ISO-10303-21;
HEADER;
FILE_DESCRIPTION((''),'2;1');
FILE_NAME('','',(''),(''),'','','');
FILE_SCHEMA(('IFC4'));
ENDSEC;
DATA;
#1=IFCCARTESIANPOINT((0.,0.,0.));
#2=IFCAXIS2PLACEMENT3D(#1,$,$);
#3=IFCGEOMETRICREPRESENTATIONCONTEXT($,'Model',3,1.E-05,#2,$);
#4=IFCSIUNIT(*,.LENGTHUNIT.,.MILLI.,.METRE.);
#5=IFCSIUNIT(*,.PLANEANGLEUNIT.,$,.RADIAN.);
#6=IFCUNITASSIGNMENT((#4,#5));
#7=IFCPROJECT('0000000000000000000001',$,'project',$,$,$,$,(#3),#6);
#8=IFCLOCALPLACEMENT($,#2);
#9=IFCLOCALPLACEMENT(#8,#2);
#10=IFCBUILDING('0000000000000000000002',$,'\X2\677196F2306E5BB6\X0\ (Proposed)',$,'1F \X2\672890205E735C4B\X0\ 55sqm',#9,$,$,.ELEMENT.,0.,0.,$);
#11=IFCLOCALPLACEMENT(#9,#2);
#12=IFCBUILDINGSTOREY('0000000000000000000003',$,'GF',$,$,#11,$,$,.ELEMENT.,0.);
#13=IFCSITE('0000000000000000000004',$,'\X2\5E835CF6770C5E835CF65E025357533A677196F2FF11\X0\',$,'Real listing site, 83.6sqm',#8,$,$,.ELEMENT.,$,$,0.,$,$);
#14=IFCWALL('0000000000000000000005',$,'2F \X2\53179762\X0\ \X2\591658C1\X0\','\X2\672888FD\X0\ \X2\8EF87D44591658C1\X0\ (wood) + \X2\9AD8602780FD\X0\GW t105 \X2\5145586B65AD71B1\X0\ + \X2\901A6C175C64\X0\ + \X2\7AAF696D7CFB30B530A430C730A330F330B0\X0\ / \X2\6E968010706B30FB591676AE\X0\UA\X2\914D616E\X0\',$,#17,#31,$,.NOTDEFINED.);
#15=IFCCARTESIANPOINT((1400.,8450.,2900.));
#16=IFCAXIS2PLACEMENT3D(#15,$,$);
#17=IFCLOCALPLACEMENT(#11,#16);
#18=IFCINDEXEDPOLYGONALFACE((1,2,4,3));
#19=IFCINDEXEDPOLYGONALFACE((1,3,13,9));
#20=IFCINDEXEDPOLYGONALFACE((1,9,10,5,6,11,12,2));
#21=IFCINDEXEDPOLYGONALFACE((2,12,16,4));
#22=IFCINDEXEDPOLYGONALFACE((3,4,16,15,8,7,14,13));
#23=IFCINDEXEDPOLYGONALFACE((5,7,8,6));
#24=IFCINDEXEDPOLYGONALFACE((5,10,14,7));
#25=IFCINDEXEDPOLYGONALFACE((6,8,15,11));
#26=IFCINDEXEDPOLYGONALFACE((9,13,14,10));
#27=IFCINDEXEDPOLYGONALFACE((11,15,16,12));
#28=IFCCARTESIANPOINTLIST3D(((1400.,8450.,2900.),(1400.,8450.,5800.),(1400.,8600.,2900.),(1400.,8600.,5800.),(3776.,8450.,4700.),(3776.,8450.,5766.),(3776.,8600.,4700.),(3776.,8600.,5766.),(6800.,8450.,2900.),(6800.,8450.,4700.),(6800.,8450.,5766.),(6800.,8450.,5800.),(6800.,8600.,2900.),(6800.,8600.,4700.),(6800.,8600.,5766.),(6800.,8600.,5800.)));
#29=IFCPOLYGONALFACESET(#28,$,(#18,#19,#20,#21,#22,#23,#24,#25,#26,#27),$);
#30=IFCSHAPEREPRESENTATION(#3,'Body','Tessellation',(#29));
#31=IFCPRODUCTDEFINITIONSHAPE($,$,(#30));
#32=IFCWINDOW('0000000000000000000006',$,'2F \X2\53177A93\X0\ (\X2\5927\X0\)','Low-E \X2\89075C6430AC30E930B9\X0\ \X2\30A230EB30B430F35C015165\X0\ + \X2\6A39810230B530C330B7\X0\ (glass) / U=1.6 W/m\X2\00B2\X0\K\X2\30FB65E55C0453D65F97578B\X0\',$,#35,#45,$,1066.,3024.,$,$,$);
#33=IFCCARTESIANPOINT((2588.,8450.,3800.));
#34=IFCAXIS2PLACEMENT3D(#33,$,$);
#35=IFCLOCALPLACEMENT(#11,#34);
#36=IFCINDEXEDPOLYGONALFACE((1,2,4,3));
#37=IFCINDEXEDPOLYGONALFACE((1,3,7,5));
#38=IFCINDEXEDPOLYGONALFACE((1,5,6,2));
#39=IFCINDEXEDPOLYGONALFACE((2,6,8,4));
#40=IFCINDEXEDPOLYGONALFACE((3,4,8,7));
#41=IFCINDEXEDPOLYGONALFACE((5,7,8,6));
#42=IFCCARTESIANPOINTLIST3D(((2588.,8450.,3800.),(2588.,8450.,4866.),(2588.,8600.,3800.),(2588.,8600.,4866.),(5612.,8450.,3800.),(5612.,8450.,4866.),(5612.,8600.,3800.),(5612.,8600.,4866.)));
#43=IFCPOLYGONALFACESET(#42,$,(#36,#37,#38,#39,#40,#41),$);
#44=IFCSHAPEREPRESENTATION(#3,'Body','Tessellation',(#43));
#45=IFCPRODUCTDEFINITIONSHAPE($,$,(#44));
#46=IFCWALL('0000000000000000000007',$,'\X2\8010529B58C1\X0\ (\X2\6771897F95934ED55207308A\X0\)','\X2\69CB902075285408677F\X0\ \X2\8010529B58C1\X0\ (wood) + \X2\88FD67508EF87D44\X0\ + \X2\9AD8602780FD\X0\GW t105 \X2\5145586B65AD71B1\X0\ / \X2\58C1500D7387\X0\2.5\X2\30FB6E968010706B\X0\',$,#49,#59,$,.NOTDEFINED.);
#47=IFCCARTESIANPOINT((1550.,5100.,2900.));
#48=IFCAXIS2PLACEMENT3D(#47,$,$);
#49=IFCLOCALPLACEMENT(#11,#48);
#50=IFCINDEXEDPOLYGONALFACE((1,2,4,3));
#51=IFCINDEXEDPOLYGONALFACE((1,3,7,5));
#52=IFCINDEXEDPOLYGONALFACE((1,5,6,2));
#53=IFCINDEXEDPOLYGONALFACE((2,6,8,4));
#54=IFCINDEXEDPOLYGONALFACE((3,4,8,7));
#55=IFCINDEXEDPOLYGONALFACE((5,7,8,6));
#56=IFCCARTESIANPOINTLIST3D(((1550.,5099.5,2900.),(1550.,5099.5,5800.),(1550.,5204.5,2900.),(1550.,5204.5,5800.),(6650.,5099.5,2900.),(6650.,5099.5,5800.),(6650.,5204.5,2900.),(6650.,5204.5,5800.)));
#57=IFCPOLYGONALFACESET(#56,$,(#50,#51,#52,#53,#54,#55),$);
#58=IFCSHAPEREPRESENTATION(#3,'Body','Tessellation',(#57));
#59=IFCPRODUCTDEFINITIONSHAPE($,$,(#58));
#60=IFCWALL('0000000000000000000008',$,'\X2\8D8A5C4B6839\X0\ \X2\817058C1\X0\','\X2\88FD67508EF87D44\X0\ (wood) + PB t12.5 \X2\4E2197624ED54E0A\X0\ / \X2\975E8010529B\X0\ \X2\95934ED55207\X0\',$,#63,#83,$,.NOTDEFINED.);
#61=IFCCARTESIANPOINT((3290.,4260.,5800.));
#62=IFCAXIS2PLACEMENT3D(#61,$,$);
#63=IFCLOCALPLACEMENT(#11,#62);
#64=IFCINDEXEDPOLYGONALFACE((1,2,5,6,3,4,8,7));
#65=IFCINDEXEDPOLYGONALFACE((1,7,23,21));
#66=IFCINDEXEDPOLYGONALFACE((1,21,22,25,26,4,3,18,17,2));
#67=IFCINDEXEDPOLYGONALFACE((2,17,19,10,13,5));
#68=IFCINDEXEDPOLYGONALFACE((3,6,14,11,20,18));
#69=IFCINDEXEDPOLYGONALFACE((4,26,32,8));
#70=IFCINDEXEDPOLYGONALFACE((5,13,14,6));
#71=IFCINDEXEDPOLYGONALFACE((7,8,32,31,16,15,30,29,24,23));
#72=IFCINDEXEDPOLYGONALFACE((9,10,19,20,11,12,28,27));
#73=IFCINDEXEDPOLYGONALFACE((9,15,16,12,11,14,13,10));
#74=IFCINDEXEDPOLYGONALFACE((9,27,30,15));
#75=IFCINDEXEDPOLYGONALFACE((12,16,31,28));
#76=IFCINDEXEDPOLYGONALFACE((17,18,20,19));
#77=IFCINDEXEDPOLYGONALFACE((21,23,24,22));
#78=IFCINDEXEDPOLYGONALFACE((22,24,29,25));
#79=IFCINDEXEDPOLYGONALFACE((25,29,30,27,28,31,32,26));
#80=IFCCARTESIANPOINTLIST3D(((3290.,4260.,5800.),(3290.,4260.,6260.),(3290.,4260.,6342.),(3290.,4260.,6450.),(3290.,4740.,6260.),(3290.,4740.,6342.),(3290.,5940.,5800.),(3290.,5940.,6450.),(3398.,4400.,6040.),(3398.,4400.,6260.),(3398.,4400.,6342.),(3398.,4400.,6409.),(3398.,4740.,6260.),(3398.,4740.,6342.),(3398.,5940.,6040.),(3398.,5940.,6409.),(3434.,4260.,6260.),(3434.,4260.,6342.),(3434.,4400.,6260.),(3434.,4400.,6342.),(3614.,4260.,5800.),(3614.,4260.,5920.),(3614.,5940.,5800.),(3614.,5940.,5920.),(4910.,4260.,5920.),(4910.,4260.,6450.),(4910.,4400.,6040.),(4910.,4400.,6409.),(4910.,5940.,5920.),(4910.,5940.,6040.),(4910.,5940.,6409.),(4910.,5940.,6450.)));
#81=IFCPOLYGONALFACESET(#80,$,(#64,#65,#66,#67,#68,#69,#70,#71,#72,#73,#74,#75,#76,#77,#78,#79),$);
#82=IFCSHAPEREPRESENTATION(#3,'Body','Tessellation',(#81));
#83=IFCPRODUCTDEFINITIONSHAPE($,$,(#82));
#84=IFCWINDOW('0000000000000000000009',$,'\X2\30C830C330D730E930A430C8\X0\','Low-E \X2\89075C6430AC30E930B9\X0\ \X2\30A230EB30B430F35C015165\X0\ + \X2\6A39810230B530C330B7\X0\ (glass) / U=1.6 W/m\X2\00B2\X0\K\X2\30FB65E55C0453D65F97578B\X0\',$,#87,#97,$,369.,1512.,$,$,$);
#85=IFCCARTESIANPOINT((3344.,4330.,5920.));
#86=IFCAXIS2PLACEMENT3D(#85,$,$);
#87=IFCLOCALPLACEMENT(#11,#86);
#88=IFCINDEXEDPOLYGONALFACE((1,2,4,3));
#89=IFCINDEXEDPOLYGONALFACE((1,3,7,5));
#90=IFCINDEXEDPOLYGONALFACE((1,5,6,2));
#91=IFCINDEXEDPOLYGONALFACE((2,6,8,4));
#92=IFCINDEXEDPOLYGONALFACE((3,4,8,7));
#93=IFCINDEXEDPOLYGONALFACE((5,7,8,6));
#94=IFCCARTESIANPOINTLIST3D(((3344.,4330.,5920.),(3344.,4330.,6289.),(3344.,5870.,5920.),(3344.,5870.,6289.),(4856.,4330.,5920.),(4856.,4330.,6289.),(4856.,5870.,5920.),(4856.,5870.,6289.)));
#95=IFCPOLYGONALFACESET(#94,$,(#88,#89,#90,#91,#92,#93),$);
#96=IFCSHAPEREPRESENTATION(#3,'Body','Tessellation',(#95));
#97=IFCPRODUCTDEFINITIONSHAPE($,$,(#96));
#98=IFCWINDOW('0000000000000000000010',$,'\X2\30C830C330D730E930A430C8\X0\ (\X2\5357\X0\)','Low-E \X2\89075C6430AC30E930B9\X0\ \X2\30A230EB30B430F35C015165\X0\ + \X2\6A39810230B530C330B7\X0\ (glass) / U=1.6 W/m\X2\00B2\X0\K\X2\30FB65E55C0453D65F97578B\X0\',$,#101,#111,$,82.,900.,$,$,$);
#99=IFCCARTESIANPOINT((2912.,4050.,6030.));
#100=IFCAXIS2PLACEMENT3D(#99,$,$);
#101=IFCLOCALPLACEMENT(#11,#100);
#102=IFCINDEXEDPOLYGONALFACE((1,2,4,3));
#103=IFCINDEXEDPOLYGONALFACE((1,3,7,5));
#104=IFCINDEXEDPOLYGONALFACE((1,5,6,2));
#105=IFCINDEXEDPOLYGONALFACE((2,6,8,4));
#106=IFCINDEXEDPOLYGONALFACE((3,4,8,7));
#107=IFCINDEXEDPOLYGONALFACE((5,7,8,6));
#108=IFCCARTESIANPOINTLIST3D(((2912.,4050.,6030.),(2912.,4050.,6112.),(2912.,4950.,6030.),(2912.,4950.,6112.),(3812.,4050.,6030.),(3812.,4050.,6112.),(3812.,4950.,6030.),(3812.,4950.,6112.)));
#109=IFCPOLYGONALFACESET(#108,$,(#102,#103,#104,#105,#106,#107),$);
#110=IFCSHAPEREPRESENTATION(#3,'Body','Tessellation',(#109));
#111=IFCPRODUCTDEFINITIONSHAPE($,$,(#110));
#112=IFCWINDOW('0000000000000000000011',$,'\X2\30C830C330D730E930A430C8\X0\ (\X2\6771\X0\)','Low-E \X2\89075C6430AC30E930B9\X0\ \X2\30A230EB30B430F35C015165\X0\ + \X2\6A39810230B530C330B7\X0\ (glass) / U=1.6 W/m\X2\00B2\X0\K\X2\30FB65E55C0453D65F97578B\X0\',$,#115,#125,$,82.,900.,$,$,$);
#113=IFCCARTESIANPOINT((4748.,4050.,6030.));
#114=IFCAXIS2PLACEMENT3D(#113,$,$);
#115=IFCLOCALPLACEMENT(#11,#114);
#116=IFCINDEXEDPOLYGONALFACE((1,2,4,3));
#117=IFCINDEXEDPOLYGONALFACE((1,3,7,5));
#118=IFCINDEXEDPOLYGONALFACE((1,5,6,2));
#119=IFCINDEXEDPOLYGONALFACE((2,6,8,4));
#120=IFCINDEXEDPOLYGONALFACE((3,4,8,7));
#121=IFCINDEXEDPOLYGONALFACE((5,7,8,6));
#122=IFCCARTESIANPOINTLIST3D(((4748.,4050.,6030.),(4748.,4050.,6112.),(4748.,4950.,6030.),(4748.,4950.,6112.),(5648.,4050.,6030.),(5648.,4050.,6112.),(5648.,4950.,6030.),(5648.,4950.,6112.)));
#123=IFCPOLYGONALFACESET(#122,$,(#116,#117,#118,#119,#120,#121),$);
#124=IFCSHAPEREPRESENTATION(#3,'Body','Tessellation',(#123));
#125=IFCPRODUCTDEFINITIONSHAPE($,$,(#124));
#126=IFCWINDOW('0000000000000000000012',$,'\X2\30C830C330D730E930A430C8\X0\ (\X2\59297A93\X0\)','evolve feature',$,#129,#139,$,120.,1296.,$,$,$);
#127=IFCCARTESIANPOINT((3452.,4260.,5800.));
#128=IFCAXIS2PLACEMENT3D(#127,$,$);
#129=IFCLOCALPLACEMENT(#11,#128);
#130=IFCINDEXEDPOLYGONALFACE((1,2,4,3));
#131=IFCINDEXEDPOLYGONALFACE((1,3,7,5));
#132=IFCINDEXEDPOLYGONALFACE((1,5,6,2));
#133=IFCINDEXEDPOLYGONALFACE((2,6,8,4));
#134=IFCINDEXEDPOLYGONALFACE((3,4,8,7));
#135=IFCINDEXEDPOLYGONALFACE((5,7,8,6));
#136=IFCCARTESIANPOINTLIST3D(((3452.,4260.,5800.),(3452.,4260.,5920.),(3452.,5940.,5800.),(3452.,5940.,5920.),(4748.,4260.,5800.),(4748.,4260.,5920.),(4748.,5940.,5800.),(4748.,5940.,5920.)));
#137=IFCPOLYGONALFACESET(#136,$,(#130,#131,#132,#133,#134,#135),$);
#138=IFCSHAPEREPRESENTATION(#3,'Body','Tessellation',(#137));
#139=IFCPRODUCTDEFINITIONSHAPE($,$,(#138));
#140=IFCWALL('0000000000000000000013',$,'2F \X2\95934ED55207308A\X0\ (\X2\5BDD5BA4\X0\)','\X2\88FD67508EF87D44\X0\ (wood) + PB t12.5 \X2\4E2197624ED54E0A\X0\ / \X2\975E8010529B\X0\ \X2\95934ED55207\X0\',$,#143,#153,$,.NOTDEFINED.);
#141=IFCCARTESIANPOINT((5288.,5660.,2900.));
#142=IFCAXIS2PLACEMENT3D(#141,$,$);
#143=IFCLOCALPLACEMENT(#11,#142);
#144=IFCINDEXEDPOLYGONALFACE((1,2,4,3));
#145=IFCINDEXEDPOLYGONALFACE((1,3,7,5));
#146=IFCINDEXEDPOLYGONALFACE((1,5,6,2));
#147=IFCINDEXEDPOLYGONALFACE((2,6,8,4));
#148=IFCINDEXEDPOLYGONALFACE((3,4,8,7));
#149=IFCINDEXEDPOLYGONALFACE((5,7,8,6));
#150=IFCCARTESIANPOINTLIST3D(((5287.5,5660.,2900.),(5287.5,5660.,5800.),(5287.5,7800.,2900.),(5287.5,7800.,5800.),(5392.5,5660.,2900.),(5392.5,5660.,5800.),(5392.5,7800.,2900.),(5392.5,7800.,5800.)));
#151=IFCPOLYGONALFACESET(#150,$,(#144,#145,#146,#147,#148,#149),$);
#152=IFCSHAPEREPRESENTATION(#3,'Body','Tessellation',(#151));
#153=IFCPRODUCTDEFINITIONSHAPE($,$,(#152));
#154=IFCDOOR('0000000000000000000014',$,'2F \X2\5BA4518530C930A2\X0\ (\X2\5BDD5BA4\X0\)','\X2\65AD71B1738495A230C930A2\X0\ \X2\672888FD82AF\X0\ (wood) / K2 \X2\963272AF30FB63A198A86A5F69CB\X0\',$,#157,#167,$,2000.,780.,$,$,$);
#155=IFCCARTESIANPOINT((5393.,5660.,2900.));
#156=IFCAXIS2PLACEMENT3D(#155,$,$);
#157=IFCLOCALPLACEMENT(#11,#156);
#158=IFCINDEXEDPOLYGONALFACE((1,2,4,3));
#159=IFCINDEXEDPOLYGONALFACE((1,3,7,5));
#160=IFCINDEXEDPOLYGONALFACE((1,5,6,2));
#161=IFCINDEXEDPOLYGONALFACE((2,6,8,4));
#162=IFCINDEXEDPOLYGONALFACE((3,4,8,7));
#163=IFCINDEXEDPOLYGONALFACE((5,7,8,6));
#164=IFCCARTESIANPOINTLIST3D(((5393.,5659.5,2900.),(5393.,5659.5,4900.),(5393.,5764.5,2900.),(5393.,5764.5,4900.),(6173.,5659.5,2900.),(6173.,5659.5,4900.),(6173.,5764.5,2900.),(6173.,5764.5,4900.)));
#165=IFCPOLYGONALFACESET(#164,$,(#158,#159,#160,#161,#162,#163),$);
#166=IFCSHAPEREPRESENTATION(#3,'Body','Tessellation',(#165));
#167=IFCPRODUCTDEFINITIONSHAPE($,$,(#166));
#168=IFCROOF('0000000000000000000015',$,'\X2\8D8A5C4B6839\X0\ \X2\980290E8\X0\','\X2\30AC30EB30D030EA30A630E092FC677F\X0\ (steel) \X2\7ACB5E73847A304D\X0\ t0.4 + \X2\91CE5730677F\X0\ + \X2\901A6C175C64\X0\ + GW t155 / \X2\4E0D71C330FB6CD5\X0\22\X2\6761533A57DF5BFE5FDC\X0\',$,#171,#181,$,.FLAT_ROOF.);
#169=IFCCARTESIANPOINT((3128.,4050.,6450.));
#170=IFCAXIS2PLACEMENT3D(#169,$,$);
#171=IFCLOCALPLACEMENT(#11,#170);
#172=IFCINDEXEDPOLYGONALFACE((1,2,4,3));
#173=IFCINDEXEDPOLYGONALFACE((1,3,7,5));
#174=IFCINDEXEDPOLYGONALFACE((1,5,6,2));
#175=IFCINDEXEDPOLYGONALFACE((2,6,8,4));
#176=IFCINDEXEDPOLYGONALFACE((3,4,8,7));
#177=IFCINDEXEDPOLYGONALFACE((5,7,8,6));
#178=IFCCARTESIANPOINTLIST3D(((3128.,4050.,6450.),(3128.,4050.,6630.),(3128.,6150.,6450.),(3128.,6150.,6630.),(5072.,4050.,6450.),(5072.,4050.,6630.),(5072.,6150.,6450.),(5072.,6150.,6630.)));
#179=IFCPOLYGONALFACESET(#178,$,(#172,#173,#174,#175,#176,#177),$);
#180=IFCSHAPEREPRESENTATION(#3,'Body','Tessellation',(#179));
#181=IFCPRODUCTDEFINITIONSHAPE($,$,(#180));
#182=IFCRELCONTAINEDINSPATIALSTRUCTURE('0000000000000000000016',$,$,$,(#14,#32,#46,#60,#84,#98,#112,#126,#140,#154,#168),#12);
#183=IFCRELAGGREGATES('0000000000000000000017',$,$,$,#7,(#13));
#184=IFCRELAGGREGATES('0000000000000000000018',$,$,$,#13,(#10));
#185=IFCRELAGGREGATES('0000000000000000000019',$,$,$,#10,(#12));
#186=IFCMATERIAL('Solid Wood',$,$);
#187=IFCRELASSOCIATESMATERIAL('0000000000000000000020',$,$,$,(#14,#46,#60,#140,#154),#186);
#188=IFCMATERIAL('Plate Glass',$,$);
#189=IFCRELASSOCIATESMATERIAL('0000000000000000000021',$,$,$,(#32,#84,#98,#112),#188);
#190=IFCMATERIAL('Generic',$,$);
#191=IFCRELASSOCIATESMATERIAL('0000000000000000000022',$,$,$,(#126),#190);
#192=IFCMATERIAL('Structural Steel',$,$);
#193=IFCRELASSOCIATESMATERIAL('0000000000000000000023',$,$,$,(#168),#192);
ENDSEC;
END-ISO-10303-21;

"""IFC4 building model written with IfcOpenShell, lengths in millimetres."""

from ifc_helpers import new_model, si_unit, frame, frame_2d, origin, place, context, project, spatial, rectangle, extrude, material, element, fill, save


model = new_model("IFC4")

# Units and contexts
model_context = context("Model", 3, precision=1e-05, world=origin())
ifc_project = project(units=[si_unit("LENGTHUNIT", "METRE", prefix="MILLI"), si_unit("PLANEANGLEUNIT", "RADIAN")], contexts=[model_context])

# Site, building, storey
site_placement = place(None, origin())
site = spatial("IfcSite", under=ifc_project, at=site_placement, Name="広島県広島市南区東雲１", ObjectType="Real listing site, 83.6sqm", CompositionType="ELEMENT", RefElevation=0.0)
building_placement = place(site_placement, origin())
building = spatial("IfcBuilding", under=site, at=building_placement, Name="東雲の家 (Proposed)", ObjectType="1F 木造平屋 55sqm", CompositionType="ELEMENT", ElevationOfRefHeight=0.0, ElevationOfTerrain=0.0)
storey_placement = place(building_placement, origin())
storey = spatial("IfcBuildingStorey", under=building, at=storey_placement, Name="GF", CompositionType="ELEMENT", Elevation=0.0)

# Wall, opening, window
ifc_material_1 = material(Name="Solid Wood")
wall_1_placement = place(storey_placement, frame((1400.0, 8450.0, 2900.0)))
wall_1 = element("IfcWall", 1, at=wall_1_placement, inside=storey, material=ifc_material_1, Name="2F 北面 外壁", Description="木製 軸組外壁 (wood) + 高性能GW t105 充填断熱 + 通気層 + 窯業系サイディング / 準耐火・外皮UA配慮", PredefinedType="NOTDEFINED", context=model_context, shape_type="SweptSolid", body=[
    extrude(rectangle(XDim=5400.0, YDim=150.0, at=frame_2d((2700.0, 75.0))), frame((1400.0, 8450.0, 2900.0)), (0.0, 0.0, 1.0), 2900.0),
])
opening_1_placement = place(storey_placement, frame((2588.0, 8450.0, 3800.0)))
opening_1 = element("IfcOpeningElement", 2, at=opening_1_placement, cuts=wall_1, PredefinedType="NOTDEFINED", context=model_context, shape_type="SweptSolid", body=[
    extrude(rectangle(XDim=3024.0, YDim=150.0, at=frame_2d((1512.0, 75.0))), frame((2588.0, 8450.0, 3800.0)), (0.0, 0.0, 1.0), 1066.0),
])
ifc_material_2 = material(Name="Plate Glass")
window_1_placement = place(storey_placement, frame((2588.0, 8450.0, 3800.0)))
window_1 = element("IfcWindow", 3, at=window_1_placement, inside=storey, material=ifc_material_2, Name="2F 北窓 (大)", Description="Low-E 複層ガラス アルゴン封入 + 樹脂サッシ (glass) / U=1.6 W/m²K・日射取得型", OverallHeight=1066.0, OverallWidth=3024.0, context=model_context, shape_type="SweptSolid", body=[
    extrude(rectangle(XDim=3024.0, YDim=150.0, at=frame_2d((1512.0, 75.0))), frame((2588.0, 8450.0, 3800.0)), (0.0, 0.0, 1.0), 1066.0),
])
fill(opening_1, window_1)

# Wall
wall_2_placement = place(storey_placement, frame((1550.0, 5100.0, 2900.0)))
element("IfcWall", 4, at=wall_2_placement, inside=storey, material=ifc_material_1, Name="耐力壁 (東西間仕切り)", Description="構造用合板 耐力壁 (wood) + 製材軸組 + 高性能GW t105 充填断熱 / 壁倍率2.5・準耐火", PredefinedType="NOTDEFINED", context=model_context, shape_type="SweptSolid", body=[
    extrude(rectangle(XDim=5100.0, YDim=105.0, at=frame_2d((2550.0, 52.0))), frame((1550.0, 5100.0, 2900.0)), (0.0, 0.0, 1.0), 2900.0),
])

# Wall, openings, windows
wall_3_placement = place(storey_placement, frame((3290.0, 4260.0, 5800.0)))
wall_3 = element("IfcWall", 5, at=wall_3_placement, inside=storey, material=ifc_material_1, Name="越屋根 腰壁", Description="製材軸組 (wood) + PB t12.5 両面仕上 / 非耐力 間仕切", PredefinedType="NOTDEFINED", context=model_context, shape_type="SweptSolid", body=[
    extrude(rectangle(XDim=1620.0, YDim=1680.0, at=frame_2d((810.0, 840.0))), frame((3290.0, 4260.0, 5800.0)), (0.0, 0.0, 1.0), 650.0),
])
opening_2_placement = place(storey_placement, frame((3344.0, 4330.0, 5920.0)))
opening_2 = element("IfcOpeningElement", 6, at=opening_2_placement, cuts=wall_3, PredefinedType="NOTDEFINED", context=model_context, shape_type="SweptSolid", body=[
    extrude(rectangle(XDim=1512.0, YDim=1540.0, at=frame_2d((756.0, 770.0))), frame((3344.0, 4330.0, 5920.0)), (0.0, 0.0, 1.0), 369.0),
])
opening_3_placement = place(storey_placement, frame((2912.0, 4050.0, 6030.0)))
opening_3 = element("IfcOpeningElement", 7, at=opening_3_placement, cuts=wall_3, PredefinedType="NOTDEFINED", context=model_context, shape_type="SweptSolid", body=[
    extrude(rectangle(XDim=900.0, YDim=900.0, at=frame_2d((450.0, 450.0))), frame((2912.0, 4050.0, 6030.0)), (0.0, 0.0, 1.0), 82.0),
])
opening_4_placement = place(storey_placement, frame((4748.0, 4050.0, 6030.0)))
opening_4 = element("IfcOpeningElement", 8, at=opening_4_placement, cuts=wall_3, PredefinedType="NOTDEFINED", context=model_context, shape_type="SweptSolid", body=[
    extrude(rectangle(XDim=900.0, YDim=900.0, at=frame_2d((450.0, 450.0))), frame((4748.0, 4050.0, 6030.0)), (0.0, 0.0, 1.0), 82.0),
])
opening_5_placement = place(storey_placement, frame((3452.0, 4260.0, 5800.0)))
opening_5 = element("IfcOpeningElement", 9, at=opening_5_placement, cuts=wall_3, PredefinedType="NOTDEFINED", context=model_context, shape_type="SweptSolid", body=[
    extrude(rectangle(XDim=1296.0, YDim=1680.0, at=frame_2d((648.0, 840.0))), frame((3452.0, 4260.0, 5800.0)), (0.0, 0.0, 1.0), 120.0),
])
window_2_placement = place(storey_placement, frame((3344.0, 4330.0, 5920.0)))
window_2 = element("IfcWindow", 10, at=window_2_placement, inside=storey, material=ifc_material_2, Name="トップライト", Description="Low-E 複層ガラス アルゴン封入 + 樹脂サッシ (glass) / U=1.6 W/m²K・日射取得型", OverallHeight=369.0, OverallWidth=1512.0, context=model_context, shape_type="SweptSolid", body=[
    extrude(rectangle(XDim=1512.0, YDim=1540.0, at=frame_2d((756.0, 770.0))), frame((3344.0, 4330.0, 5920.0)), (0.0, 0.0, 1.0), 369.0),
])
fill(opening_2, window_2)
window_3_placement = place(storey_placement, frame((2912.0, 4050.0, 6030.0)))
window_3 = element("IfcWindow", 11, at=window_3_placement, inside=storey, material=ifc_material_2, Name="トップライト (南)", Description="Low-E 複層ガラス アルゴン封入 + 樹脂サッシ (glass) / U=1.6 W/m²K・日射取得型", OverallHeight=82.0, OverallWidth=900.0, context=model_context, shape_type="SweptSolid", body=[
    extrude(rectangle(XDim=900.0, YDim=900.0, at=frame_2d((450.0, 450.0))), frame((2912.0, 4050.0, 6030.0)), (0.0, 0.0, 1.0), 82.0),
])
fill(opening_3, window_3)
window_4_placement = place(storey_placement, frame((4748.0, 4050.0, 6030.0)))
window_4 = element("IfcWindow", 12, at=window_4_placement, inside=storey, material=ifc_material_2, Name="トップライト (東)", Description="Low-E 複層ガラス アルゴン封入 + 樹脂サッシ (glass) / U=1.6 W/m²K・日射取得型", OverallHeight=82.0, OverallWidth=900.0, context=model_context, shape_type="SweptSolid", body=[
    extrude(rectangle(XDim=900.0, YDim=900.0, at=frame_2d((450.0, 450.0))), frame((4748.0, 4050.0, 6030.0)), (0.0, 0.0, 1.0), 82.0),
])
fill(opening_4, window_4)
ifc_material_3 = material(Name="Generic")
window_5_placement = place(storey_placement, frame((3452.0, 4260.0, 5800.0)))
window_5 = element("IfcWindow", 13, at=window_5_placement, inside=storey, material=ifc_material_3, Name="トップライト (天窓)", Description="evolve feature", OverallHeight=120.0, OverallWidth=1296.0, context=model_context, shape_type="SweptSolid", body=[
    extrude(rectangle(XDim=1296.0, YDim=1680.0, at=frame_2d((648.0, 840.0))), frame((3452.0, 4260.0, 5800.0)), (0.0, 0.0, 1.0), 120.0),
])
fill(opening_5, window_5)

# Wall
wall_4_placement = place(storey_placement, frame((5288.0, 5660.0, 2900.0)))
element("IfcWall", 14, at=wall_4_placement, inside=storey, material=ifc_material_1, Name="2F 間仕切り (寝室)", Description="製材軸組 (wood) + PB t12.5 両面仕上 / 非耐力 間仕切", PredefinedType="NOTDEFINED", context=model_context, shape_type="SweptSolid", body=[
    extrude(rectangle(XDim=105.0, YDim=2140.0, at=frame_2d((52.0, 1070.0))), frame((5288.0, 5660.0, 2900.0)), (0.0, 0.0, 1.0), 2900.0),
])

# Door
door_placement = place(storey_placement, frame((5393.0, 5660.0, 2900.0)))
element("IfcDoor", 15, at=door_placement, inside=storey, material=ifc_material_1, Name="2F 室内ドア (寝室)", Description="断熱玄関ドア 木製芯 (wood) / K2 防犯・採風機構", OverallHeight=2000.0, OverallWidth=780.0, context=model_context, shape_type="SweptSolid", body=[
    extrude(rectangle(XDim=780.0, YDim=105.0, at=frame_2d((390.0, 52.0))), frame((5393.0, 5660.0, 2900.0)), (0.0, 0.0, 1.0), 2000.0),
])

# Roof
ifc_material_4 = material(Name="Structural Steel")
roof_placement = place(storey_placement, frame((3128.0, 4050.0, 6450.0)))
element("IfcRoof", 16, at=roof_placement, inside=storey, material=ifc_material_4, Name="越屋根 頂部", Description="ガルバリウム鋼板 (steel) 立平葺き t0.4 + 野地板 + 通気層 + GW t155 / 不燃・法22条区域対応", PredefinedType="FLAT_ROOF", context=model_context, shape_type="SweptSolid", body=[
    extrude(rectangle(XDim=1944.0, YDim=2100.0, at=frame_2d((972.0, 1050.0))), frame((3128.0, 4050.0, 6450.0)), (0.0, 0.0, 1.0), 180.0),
])

save(model, "model.ifc")
